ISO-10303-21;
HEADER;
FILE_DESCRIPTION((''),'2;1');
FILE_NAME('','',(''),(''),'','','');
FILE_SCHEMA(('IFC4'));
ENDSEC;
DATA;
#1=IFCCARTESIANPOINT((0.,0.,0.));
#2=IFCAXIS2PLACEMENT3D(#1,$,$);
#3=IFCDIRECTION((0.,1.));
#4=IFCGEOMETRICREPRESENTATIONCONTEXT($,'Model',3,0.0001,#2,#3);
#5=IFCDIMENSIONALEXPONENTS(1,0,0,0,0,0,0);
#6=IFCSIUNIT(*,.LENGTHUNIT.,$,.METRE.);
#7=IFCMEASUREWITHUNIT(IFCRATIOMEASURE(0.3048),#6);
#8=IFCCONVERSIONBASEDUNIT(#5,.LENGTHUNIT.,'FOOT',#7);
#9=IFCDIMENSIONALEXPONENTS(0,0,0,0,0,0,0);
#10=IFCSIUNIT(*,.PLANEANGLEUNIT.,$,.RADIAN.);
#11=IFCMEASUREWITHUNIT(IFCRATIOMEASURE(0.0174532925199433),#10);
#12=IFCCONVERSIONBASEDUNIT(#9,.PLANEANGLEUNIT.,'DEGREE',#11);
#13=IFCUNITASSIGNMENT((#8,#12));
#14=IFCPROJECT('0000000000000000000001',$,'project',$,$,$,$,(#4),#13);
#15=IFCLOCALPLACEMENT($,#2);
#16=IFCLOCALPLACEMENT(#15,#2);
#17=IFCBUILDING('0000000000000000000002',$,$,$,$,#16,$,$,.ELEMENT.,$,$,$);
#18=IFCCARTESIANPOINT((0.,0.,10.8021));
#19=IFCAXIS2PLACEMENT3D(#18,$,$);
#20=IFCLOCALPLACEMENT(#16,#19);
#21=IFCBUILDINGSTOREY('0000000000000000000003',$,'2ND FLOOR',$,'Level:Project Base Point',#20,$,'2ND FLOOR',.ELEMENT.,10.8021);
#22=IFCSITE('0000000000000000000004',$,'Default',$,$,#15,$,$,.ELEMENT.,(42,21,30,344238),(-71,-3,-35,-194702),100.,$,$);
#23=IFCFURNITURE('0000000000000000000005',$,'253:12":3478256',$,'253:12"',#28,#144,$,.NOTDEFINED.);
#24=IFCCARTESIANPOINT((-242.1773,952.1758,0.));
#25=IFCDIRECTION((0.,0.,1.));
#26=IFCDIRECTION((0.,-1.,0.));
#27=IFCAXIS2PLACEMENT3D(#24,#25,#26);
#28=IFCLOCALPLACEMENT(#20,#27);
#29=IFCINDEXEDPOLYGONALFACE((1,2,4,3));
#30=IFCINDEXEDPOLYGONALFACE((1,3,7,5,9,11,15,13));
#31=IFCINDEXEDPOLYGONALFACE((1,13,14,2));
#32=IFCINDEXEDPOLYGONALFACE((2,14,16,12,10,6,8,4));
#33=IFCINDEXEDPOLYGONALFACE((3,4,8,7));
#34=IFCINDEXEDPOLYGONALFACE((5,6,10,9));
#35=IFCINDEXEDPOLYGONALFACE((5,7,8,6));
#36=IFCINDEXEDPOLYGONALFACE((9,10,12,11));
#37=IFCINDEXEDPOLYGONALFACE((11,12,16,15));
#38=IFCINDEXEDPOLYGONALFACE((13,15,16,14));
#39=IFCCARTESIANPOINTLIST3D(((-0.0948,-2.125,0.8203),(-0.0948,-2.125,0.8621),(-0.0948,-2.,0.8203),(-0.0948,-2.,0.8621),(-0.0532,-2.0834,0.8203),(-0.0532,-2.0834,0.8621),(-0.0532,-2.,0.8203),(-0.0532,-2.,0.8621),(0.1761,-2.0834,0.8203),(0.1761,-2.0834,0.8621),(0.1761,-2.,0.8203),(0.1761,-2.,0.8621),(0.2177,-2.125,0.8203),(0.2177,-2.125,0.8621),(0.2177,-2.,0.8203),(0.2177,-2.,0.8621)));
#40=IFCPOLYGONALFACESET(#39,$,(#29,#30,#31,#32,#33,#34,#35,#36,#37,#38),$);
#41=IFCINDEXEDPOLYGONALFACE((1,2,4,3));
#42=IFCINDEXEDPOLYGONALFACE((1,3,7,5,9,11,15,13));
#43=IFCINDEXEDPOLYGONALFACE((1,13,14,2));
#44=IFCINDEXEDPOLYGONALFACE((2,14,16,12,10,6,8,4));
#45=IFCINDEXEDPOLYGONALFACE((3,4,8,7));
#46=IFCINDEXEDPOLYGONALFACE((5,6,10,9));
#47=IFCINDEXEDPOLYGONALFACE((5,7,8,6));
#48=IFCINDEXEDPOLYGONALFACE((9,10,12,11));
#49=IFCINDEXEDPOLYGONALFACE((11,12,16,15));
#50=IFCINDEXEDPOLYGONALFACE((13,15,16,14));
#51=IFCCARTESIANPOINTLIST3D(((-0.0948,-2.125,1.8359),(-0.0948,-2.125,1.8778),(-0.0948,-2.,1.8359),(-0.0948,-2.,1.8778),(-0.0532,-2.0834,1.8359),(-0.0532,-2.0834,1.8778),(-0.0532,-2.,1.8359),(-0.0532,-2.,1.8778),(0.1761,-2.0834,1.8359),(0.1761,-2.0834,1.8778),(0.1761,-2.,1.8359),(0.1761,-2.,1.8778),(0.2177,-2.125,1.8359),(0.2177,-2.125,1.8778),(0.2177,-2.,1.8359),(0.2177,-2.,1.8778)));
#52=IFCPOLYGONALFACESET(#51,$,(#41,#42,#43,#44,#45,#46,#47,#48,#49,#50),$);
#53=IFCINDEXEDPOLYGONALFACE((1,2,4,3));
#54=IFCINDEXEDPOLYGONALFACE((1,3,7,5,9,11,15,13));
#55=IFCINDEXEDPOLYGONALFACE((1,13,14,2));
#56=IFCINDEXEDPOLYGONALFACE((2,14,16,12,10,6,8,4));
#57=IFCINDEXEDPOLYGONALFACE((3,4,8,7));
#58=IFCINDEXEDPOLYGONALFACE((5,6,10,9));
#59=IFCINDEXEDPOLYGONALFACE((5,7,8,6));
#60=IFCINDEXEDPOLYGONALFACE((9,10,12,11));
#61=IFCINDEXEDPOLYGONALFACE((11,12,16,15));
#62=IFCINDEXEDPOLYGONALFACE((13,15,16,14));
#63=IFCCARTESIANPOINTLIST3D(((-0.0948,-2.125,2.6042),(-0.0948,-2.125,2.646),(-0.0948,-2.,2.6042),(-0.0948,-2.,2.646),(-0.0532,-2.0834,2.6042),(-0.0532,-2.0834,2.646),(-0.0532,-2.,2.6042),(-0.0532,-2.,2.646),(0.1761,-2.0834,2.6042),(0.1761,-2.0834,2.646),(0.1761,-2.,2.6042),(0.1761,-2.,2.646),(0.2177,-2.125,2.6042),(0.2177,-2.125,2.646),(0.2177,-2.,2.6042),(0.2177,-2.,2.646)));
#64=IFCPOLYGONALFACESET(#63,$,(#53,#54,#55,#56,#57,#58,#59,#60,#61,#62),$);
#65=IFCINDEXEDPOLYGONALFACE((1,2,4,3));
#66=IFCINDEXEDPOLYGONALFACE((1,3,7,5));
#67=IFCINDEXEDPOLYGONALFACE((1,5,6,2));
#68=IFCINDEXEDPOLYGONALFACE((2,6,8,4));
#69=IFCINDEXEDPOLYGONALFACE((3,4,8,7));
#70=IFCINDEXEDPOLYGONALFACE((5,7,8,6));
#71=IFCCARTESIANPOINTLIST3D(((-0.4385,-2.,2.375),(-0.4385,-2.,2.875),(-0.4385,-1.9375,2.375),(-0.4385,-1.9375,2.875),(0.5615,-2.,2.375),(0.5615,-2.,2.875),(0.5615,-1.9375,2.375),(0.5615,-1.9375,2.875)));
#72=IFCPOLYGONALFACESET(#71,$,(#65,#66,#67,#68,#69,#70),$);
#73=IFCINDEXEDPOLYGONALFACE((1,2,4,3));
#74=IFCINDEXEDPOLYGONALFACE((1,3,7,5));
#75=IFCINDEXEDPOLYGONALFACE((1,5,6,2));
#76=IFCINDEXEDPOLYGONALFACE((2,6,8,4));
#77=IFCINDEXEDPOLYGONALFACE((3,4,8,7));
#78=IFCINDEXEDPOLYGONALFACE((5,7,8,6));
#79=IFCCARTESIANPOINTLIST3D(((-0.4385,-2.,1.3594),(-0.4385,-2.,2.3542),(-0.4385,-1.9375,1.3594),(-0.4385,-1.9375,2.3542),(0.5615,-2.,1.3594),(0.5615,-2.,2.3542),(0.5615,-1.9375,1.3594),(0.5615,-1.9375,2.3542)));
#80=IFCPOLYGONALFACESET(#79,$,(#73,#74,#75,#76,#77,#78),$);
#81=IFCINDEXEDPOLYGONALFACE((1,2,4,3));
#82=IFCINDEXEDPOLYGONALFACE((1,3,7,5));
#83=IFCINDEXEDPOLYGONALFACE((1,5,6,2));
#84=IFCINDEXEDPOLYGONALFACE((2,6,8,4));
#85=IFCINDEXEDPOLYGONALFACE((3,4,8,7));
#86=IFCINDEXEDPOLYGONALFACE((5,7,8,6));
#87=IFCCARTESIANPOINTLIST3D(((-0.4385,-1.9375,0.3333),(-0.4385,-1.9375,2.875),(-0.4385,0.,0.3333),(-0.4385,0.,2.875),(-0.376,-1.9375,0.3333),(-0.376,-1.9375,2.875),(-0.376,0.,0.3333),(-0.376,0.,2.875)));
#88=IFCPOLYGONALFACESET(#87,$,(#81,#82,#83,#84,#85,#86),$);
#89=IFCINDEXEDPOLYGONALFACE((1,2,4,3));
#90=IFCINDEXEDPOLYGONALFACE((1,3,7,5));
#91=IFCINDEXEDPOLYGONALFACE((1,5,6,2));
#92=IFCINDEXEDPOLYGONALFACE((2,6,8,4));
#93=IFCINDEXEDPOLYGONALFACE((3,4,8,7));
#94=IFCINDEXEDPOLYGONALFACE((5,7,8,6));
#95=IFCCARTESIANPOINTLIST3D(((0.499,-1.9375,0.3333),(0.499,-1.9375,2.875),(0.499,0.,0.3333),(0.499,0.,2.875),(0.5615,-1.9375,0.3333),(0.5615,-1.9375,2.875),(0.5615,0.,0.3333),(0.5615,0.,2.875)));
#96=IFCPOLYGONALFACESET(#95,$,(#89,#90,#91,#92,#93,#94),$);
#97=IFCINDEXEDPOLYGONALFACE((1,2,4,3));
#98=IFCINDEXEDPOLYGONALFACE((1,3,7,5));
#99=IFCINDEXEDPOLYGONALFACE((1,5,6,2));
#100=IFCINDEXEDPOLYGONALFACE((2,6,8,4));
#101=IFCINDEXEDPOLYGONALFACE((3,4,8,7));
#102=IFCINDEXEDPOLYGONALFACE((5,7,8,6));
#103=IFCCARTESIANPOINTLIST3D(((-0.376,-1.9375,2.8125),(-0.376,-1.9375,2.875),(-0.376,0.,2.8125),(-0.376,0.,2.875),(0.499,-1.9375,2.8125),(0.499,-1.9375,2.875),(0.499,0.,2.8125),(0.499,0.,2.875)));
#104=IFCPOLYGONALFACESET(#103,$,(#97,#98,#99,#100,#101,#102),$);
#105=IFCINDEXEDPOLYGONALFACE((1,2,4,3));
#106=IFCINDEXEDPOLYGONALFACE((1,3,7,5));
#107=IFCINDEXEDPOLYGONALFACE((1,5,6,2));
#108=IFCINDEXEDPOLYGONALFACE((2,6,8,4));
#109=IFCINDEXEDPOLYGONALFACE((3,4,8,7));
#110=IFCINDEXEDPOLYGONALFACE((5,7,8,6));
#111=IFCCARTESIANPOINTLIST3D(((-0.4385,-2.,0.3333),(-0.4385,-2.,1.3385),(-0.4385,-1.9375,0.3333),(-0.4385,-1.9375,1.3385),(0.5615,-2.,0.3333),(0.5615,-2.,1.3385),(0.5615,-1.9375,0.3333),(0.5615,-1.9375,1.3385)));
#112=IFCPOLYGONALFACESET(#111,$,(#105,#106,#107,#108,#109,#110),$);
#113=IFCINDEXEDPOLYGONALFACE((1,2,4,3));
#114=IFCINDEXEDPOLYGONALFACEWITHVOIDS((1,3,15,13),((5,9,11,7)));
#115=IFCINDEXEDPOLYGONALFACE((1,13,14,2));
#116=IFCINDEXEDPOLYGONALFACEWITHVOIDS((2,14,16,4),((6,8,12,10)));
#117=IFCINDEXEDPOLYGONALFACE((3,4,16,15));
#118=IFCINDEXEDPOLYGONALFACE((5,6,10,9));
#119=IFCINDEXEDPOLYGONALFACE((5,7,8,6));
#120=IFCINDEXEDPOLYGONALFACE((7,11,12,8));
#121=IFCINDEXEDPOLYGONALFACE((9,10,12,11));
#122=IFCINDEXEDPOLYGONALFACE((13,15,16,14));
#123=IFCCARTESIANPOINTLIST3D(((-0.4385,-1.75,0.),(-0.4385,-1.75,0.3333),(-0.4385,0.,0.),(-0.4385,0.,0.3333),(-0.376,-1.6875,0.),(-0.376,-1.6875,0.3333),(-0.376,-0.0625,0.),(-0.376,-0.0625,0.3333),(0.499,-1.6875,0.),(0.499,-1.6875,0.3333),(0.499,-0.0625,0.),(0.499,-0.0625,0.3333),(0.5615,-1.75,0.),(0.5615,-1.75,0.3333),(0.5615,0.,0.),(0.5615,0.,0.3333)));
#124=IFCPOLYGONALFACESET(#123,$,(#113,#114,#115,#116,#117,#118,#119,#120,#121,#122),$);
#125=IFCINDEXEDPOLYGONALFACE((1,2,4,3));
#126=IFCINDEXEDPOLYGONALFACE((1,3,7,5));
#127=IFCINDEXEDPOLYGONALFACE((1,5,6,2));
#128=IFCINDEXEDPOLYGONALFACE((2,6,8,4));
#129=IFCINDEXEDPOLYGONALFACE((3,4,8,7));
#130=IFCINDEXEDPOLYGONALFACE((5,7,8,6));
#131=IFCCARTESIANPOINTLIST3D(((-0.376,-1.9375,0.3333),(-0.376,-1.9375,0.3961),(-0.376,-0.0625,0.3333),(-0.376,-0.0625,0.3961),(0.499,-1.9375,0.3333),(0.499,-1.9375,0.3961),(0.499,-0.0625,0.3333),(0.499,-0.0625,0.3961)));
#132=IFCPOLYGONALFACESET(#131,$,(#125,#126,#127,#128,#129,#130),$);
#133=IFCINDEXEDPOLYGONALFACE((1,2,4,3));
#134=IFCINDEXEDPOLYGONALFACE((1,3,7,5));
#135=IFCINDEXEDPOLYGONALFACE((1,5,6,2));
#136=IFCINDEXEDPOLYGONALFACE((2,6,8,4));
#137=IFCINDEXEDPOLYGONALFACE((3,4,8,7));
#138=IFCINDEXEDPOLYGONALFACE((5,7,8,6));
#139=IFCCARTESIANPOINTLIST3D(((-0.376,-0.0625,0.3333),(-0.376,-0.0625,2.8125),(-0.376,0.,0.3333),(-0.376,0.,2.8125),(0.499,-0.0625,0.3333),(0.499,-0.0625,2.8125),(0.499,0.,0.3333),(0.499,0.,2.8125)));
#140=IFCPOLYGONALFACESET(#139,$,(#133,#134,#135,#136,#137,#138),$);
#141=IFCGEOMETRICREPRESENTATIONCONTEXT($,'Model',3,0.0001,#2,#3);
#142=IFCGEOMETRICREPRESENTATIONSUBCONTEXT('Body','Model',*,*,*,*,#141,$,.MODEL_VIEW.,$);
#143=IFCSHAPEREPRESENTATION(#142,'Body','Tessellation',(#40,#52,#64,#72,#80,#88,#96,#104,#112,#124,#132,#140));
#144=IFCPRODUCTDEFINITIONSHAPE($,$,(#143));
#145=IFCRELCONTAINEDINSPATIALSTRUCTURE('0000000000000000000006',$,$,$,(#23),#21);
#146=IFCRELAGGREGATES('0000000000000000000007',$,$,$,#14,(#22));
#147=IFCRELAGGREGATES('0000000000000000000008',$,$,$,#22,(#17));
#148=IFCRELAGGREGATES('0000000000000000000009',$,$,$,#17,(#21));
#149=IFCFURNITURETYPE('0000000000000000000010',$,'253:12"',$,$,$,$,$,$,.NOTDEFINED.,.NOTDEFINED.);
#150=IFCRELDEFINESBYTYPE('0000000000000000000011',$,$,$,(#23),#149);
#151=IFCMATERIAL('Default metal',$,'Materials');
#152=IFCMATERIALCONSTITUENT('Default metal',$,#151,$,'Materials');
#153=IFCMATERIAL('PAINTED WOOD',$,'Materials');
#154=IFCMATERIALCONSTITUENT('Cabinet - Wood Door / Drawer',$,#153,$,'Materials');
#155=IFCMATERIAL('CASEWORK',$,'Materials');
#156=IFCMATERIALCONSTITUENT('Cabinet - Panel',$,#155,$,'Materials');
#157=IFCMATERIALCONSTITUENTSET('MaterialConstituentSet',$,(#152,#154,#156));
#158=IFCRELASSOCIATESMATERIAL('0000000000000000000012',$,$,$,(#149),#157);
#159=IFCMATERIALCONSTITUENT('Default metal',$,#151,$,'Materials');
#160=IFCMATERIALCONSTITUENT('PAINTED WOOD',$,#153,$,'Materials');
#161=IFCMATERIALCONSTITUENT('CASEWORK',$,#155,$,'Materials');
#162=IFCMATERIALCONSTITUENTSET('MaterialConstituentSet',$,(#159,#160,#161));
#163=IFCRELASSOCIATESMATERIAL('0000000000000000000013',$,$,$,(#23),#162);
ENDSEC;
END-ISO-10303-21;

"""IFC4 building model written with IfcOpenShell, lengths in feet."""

from ifc_helpers import new_model, entity, si_unit, converted_unit, direction, frame, frame_2d, origin, origin_2d_with_axis, place, context, subcontext, project, spatial, polyline, rectangle, outline, extrude, source, transform, mapped, material, constituent, constituent_set, type_object, type_shapes, element, save


model = new_model("IFC4")

# Units and contexts
model_context_1 = context("Model", 3, precision=0.0001, world=origin(), true_north=direction((0.0, 1.0)))
model_context_2 = context("Model", 3, precision=0.0001, world=origin(), true_north=direction((0.0, 1.0)))
body_context = subcontext(model_context_2, "Body", "Model", "MODEL_VIEW")
ifc_project = project(units=[converted_unit("LENGTHUNIT", "FOOT", entity("IfcRatioMeasure", 0.3048), si_unit("LENGTHUNIT", "METRE"), dimensions=[1, 0, 0, 0, 0, 0, 0]), converted_unit("PLANEANGLEUNIT", "DEGREE", entity("IfcRatioMeasure", 0.0174532925199433), si_unit("PLANEANGLEUNIT", "RADIAN"), dimensions=[0, 0, 0, 0, 0, 0, 0])], contexts=[model_context_1])

# Site, building, storey
site_placement = place(None, origin())
site = spatial("IfcSite", under=ifc_project, at=site_placement, Name="Default", CompositionType="ELEMENT", RefLatitude=(42, 21, 30, 344238), RefLongitude=(-71, -3, -35, -194702), RefElevation=100.0)
building_placement = place(site_placement, origin())
building = spatial("IfcBuilding", under=site, at=building_placement, CompositionType="ELEMENT")
storey_placement = place(building_placement, frame((0.0, 0.0, 10.8021)))
storey = spatial("IfcBuildingStorey", under=building, at=storey_placement, Name="2ND FLOOR", ObjectType="Level:Project Base Point", LongName="2ND FLOOR", CompositionType="ELEMENT", Elevation=10.8021)

# Furniture
ifc_material_1 = material(Name="Default metal", Category="Materials")
ifc_constituent_1 = constituent(ifc_material_1, Name="Default metal", Category="Materials")
ifc_material_2 = material(Name="PAINTED WOOD", Category="Materials")
ifc_constituent_2 = constituent(ifc_material_2, Name="PAINTED WOOD", Category="Materials")
ifc_material_3 = material(Name="CASEWORK", Category="Materials")
ifc_constituent_3 = constituent(ifc_material_3, Name="CASEWORK", Category="Materials")
ifc_constituent_set_1 = constituent_set(constituents=[ifc_constituent_1, ifc_constituent_2, ifc_constituent_3], Name="MaterialConstituentSet")
ifc_constituent_4 = constituent(ifc_material_1, Name="Default metal", Category="Materials")
ifc_constituent_5 = constituent(ifc_material_2, Name="Cabinet - Wood Door / Drawer", Category="Materials")
ifc_constituent_6 = constituent(ifc_material_3, Name="Cabinet - Panel", Category="Materials")
ifc_constituent_set_2 = constituent_set(constituents=[ifc_constituent_4, ifc_constituent_5, ifc_constituent_6], Name="MaterialConstituentSet")
furniture_type_1 = type_object("IfcFurnitureType", Name="253:12\"", AssemblyPlace="NOTDEFINED", PredefinedType="NOTDEFINED", material=ifc_constituent_set_2)
shared_shape_1 = source(origin(), body_context, "Body", "SweptSolid", [
    extrude(outline(polyline([(-0.0521, -0.1562), (0.0729, -0.1562), (0.0729, 0.1562), (-0.0521, 0.1562), (-0.0521, 0.1146), (0.0313, 0.1146), (0.0313, -0.1146), (-0.0521, -0.1146), (-0.0521, -0.1562)])), frame((0.0615, -2.0521, 0.8203), z_axis=(0.0, 0.0, 1.0), x_axis=(0.0, -1.0, 0.0)), (0.0, 0.0, 1.0), 0.0418),
    extrude(outline(polyline([(-0.0521, -0.1562), (0.0729, -0.1562), (0.0729, 0.1562), (-0.0521, 0.1562), (-0.0521, 0.1146), (0.0313, 0.1146), (0.0313, -0.1146), (-0.0521, -0.1146), (-0.0521, -0.1562)])), frame((0.0615, -2.0521, 1.8359), z_axis=(0.0, 0.0, 1.0), x_axis=(0.0, -1.0, 0.0)), (0.0, 0.0, 1.0), 0.0418),
    extrude(outline(polyline([(-0.0521, -0.1562), (0.0729, -0.1562), (0.0729, 0.1562), (-0.0521, 0.1562), (-0.0521, 0.1146), (0.0313, 0.1146), (0.0313, -0.1146), (-0.0521, -0.1146), (-0.0521, -0.1562)])), frame((0.0615, -2.0521, 2.6042), z_axis=(0.0, 0.0, 1.0), x_axis=(0.0, -1.0, 0.0)), (0.0, 0.0, 1.0), 0.0418),
    extrude(rectangle(XDim=0.0625, YDim=1.0, at=origin_2d_with_axis()), frame((0.0615, -1.9688, 2.375), z_axis=(0.0, 0.0, 1.0), x_axis=(0.0, 1.0, 0.0)), (0.0, 0.0, 1.0), 0.5),
    extrude(rectangle(XDim=0.0625, YDim=1.0, at=origin_2d_with_axis()), frame((0.0615, -1.9688, 1.3594), z_axis=(0.0, 0.0, 1.0), x_axis=(0.0, 1.0, 0.0)), (0.0, 0.0, 1.0), 0.9948),
    extrude(rectangle(XDim=0.0625, YDim=1.9375, at=frame_2d((0.0, 0.0), x_axis=(1.0, 0.0))), frame((-0.4073, -0.9687, 0.3333)), (0.0, 0.0, 1.0), 2.5417),
    extrude(rectangle(XDim=0.0625, YDim=1.9375, at=frame_2d((0.0, 0.0), x_axis=(1.0, 0.0))), frame((0.5302, -0.9687, 0.3333)), (0.0, 0.0, 1.0), 2.5417),
    extrude(rectangle(XDim=0.875, YDim=1.9375, at=origin_2d_with_axis()), frame((0.0615, -0.9688, 2.8125), z_axis=(0.0, 0.0, 1.0), x_axis=(-1.0, 0.0, 0.0)), (0.0, 0.0, 1.0), 0.0625),
    extrude(rectangle(XDim=0.0625, YDim=1.0, at=origin_2d_with_axis()), frame((0.0615, -1.9688, 0.3333), z_axis=(0.0, 0.0, 1.0), x_axis=(0.0, 1.0, 0.0)), (0.0, 0.0, 1.0), 1.0052),
    extrude(outline(polyline([(-0.5, -0.875), (0.5, -0.875), (0.5, 0.875), (-0.5, 0.875), (-0.5, -0.875)]), holes=[polyline([(-0.4375, -0.8125), (-0.4375, 0.8125), (0.4375, 0.8125), (0.4375, -0.8125), (-0.4375, -0.8125)])]), frame((0.0615, -0.875, 0.0)), (0.0, 0.0, 1.0), 0.3333),
    extrude(rectangle(XDim=0.875, YDim=1.875, at=frame_2d((0.0, 0.0), x_axis=(1.0, 0.0))), frame((0.0615, -1.0, 0.3333), z_axis=(0.0, 0.0, 1.0), x_axis=(-1.0, 0.0, 0.0)), (0.0, 0.0, 1.0), 0.0627),
    extrude(rectangle(XDim=0.0625, YDim=0.875, at=origin_2d_with_axis()), frame((0.0615, -0.0312, 0.3333), z_axis=(0.0, 0.0, 1.0), x_axis=(0.0, 1.0, 0.0)), (0.0, 0.0, 1.0), 2.4792),
])
type_shapes(furniture_type_1, [shared_shape_1])
furniture_1_placement = place(storey_placement, frame((-242.1773, 952.1758, 0.0), z_axis=(0.0, 0.0, 1.0), x_axis=(0.0, -1.0, 0.0)))
element("IfcFurniture", 1, at=furniture_1_placement, inside=storey, type_object=furniture_type_1, material=ifc_constituent_set_1, Name="253:12\":3478256", ObjectType="253:12\"", PredefinedType="NOTDEFINED", context=body_context, shape_type="MappedRepresentation", body=[
    mapped(shared_shape_1, transform((0.0, 0.0, 0.0), scale=1.0)),
])

save(model, "model.ifc")
